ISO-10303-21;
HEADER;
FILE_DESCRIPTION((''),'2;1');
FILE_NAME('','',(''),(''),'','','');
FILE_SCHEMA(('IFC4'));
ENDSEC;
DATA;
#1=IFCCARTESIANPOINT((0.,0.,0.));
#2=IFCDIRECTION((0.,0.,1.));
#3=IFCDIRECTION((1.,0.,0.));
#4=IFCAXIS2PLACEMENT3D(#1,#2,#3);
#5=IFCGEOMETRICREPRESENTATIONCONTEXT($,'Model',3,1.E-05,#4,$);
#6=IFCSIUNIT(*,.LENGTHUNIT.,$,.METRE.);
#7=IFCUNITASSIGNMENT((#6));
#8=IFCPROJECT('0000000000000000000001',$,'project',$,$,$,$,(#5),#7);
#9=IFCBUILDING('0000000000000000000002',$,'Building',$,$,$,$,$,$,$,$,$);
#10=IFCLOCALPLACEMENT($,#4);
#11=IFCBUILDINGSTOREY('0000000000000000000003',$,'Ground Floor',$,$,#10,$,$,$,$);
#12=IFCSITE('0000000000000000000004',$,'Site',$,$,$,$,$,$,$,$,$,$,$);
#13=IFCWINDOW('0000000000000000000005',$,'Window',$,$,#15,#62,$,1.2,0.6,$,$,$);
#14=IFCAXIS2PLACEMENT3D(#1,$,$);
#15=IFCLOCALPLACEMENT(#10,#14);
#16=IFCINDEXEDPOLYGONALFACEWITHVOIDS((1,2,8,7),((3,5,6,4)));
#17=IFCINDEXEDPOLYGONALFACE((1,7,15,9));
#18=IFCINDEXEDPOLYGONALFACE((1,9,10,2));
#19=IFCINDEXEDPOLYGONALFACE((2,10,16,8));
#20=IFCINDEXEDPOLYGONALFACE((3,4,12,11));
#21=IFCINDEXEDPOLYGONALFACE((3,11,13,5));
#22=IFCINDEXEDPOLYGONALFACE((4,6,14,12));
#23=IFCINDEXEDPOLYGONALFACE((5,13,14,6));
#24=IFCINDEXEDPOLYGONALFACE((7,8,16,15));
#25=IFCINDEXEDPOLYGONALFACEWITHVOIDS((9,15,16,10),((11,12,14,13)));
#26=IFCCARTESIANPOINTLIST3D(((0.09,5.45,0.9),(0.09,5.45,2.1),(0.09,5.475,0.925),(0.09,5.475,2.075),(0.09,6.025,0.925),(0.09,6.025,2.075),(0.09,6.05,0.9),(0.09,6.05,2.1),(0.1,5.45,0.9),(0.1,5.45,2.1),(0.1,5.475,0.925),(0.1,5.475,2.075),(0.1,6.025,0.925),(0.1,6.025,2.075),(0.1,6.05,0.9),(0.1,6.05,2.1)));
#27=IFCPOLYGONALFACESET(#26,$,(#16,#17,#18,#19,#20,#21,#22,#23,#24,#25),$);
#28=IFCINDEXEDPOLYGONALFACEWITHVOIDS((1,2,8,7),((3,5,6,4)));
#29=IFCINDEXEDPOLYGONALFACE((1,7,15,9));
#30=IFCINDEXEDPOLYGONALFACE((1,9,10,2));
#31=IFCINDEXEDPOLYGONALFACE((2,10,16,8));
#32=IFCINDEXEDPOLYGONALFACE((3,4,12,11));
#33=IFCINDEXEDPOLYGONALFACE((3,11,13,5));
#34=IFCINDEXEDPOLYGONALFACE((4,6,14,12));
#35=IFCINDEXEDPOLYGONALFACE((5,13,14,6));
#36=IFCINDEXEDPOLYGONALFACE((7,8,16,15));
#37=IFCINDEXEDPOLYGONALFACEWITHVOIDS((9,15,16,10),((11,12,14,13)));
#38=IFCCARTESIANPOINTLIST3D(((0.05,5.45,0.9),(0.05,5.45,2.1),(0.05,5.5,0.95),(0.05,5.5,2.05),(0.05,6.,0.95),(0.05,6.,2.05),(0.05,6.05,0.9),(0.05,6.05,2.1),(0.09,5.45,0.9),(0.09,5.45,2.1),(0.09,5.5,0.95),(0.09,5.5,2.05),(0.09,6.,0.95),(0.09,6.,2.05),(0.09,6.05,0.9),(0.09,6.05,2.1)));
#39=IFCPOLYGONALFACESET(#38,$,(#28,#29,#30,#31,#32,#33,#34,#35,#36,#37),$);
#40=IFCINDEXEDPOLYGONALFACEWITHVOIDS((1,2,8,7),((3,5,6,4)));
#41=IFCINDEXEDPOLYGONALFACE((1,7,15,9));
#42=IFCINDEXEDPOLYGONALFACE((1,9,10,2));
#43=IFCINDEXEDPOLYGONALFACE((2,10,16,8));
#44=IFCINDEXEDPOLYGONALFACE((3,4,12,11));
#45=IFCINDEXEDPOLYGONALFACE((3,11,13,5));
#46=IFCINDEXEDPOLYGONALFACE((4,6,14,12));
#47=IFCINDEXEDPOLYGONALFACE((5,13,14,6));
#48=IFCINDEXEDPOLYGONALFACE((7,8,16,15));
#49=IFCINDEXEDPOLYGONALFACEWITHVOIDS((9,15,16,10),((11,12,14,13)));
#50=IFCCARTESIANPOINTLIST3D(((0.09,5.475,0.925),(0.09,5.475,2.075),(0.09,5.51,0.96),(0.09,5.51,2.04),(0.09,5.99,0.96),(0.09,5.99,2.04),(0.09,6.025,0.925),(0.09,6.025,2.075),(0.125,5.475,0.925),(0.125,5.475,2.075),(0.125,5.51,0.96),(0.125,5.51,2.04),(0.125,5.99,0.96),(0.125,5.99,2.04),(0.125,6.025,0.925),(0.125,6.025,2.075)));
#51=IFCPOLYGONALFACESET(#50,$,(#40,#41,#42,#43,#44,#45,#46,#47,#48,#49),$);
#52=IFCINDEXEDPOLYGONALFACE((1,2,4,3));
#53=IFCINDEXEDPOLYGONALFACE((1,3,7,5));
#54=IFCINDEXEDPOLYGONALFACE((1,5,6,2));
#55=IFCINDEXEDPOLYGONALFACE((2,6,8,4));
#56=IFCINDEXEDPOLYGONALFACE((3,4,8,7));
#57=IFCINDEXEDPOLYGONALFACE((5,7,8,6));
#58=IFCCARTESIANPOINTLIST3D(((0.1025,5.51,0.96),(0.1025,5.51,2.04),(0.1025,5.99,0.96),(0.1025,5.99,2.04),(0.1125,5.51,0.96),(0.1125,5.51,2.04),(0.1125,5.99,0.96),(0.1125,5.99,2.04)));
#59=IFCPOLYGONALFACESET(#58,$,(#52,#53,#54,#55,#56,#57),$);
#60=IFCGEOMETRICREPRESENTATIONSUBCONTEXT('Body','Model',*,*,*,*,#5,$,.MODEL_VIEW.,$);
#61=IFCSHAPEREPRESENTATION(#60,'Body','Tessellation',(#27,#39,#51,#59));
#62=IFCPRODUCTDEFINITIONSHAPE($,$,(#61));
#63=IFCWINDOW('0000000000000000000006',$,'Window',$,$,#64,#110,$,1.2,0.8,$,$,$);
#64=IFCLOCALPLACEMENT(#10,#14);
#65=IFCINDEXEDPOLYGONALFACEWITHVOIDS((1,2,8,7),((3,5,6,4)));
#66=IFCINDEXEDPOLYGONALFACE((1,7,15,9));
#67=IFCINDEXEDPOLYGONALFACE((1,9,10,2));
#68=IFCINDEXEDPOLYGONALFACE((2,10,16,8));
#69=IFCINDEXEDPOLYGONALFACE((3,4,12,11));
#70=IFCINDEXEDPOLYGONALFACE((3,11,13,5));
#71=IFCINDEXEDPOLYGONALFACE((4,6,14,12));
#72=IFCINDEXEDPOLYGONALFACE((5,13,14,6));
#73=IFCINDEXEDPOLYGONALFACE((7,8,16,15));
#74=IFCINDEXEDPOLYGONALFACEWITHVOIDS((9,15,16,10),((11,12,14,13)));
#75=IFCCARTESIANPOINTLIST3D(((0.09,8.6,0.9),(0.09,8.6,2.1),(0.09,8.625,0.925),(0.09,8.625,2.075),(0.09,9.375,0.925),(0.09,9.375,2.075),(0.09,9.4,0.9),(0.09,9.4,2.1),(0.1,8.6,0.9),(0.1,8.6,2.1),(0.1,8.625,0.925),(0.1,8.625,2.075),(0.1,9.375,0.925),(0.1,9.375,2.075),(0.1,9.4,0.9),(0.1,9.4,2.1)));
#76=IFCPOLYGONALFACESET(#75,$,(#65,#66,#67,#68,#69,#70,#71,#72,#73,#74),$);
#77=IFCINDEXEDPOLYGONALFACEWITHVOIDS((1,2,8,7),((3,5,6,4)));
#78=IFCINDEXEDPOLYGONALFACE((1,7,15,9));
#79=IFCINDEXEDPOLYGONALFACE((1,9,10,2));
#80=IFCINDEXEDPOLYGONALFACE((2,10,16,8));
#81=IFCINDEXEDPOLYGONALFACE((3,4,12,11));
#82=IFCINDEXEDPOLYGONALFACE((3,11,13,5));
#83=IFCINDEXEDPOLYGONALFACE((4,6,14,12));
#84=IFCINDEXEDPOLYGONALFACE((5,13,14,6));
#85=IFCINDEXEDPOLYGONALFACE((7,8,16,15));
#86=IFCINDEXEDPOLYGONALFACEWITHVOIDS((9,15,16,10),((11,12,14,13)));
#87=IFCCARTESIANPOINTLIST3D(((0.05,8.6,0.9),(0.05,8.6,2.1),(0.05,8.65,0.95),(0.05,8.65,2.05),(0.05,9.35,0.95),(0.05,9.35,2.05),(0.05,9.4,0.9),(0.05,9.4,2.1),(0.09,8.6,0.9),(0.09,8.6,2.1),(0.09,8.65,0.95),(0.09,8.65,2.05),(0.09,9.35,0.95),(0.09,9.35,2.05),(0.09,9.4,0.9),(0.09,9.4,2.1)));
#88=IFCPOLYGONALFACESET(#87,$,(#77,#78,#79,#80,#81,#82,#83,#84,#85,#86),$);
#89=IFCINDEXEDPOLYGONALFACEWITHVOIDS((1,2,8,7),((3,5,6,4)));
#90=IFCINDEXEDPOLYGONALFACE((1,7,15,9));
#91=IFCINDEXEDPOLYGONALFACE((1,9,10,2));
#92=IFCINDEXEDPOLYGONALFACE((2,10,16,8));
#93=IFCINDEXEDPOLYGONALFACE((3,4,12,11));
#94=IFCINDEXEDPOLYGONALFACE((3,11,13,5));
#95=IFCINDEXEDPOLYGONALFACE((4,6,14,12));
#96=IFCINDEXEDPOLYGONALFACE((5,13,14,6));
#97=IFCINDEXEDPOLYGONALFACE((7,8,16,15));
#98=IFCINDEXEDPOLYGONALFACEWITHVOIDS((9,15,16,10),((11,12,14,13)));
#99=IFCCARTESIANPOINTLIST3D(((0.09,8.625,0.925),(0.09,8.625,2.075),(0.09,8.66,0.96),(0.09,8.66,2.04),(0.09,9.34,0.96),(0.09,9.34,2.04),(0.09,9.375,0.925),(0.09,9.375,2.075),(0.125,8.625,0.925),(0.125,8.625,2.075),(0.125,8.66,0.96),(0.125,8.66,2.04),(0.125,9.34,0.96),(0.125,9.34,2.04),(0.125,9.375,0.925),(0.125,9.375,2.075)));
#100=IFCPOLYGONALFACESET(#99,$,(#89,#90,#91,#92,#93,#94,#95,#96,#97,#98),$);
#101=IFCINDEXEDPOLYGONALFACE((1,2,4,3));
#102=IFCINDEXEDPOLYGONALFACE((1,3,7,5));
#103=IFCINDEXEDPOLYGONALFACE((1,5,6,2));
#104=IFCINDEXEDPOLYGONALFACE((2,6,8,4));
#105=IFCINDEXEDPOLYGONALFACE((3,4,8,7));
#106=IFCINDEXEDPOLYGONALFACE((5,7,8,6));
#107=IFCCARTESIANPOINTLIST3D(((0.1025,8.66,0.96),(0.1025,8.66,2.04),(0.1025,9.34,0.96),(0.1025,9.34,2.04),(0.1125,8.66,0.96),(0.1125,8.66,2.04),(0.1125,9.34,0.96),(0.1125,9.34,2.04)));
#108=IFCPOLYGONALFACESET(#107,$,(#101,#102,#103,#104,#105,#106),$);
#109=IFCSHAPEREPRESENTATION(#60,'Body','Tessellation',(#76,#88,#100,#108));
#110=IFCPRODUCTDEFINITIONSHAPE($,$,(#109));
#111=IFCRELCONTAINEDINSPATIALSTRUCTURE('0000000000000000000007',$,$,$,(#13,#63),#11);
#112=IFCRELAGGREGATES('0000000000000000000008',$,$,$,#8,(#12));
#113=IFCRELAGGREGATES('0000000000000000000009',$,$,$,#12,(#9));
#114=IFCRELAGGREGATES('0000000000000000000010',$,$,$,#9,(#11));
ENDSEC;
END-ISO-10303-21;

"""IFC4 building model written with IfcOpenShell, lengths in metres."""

from ifc_helpers import new_model, si_unit, frame, origin_with_axes, place, context, subcontext, project, spatial, line, indexed_curve, outline, extrude, element, save


model = new_model("IFC4")

# Units and contexts
model_context = context("Model", 3, precision=1e-05, world=origin_with_axes())
body_context = subcontext(model_context, "Body", "Model", "MODEL_VIEW")
ifc_project = project(units=[si_unit("LENGTHUNIT", "METRE")], contexts=[model_context])

# Site, building, storey
site = spatial("IfcSite", under=ifc_project, Name="Site")
building = spatial("IfcBuilding", under=site, Name="Building")
storey_placement = place(None, origin_with_axes())
storey = spatial("IfcBuildingStorey", under=building, at=storey_placement, Name="Ground Floor")

# Windows
window_1_placement = place(storey_placement, frame((0.0, 6.05, 0.9), z_axis=(0.0, 0.0, 1.0), x_axis=(0.0, -1.0, 0.0)))
element("IfcWindow", 1, at=window_1_placement, inside=storey, Name="Window", OverallHeight=1.2, OverallWidth=0.6, context=body_context, shape_type="SweptSolid", body=[
    extrude(outline(indexed_curve([(0.0, 0.0), (0.6, 0.0), (0.6, 1.2), (0.0, 1.2)], segments=[line(1, 2, 3, 4, 1)]), holes=[indexed_curve([(0.025, 0.025), (0.575, 0.025), (0.575, 1.175), (0.025, 1.175)], segments=[line(1, 2, 3, 4, 1)])]), frame((0.0, 0.09, 0.0), z_axis=(0.0, -1.0, 0.0), x_axis=(1.0, 0.0, 0.0)), (0.0, 0.0, -1.0), 0.01),
    extrude(outline(indexed_curve([(0.0, 0.0), (0.6, 0.0), (0.6, 1.2), (0.0, 1.2)], segments=[line(1, 2, 3, 4, 1)]), holes=[indexed_curve([(0.05, 0.05), (0.55, 0.05), (0.55, 1.15), (0.05, 1.15)], segments=[line(1, 2, 3, 4, 1)])]), frame((0.0, 0.05, 0.0), z_axis=(0.0, -1.0, 0.0), x_axis=(1.0, 0.0, 0.0)), (0.0, 0.0, -1.0), 0.04),
    extrude(outline(indexed_curve([(0.0, 0.0), (0.55, 0.0), (0.55, 1.15), (0.0, 1.15)], segments=[line(1, 2, 3, 4, 1)]), holes=[indexed_curve([(0.035, 0.035), (0.515, 0.035), (0.515, 1.115), (0.035, 1.115)], segments=[line(1, 2, 3, 4, 1)])]), frame((0.025, 0.09, 0.025), z_axis=(0.0, -1.0, 0.0), x_axis=(1.0, 0.0, 0.0)), (0.0, 0.0, -1.0), 0.035),
    extrude(outline(indexed_curve([(0.035, 0.035), (0.515, 0.035), (0.515, 1.115), (0.035, 1.115)], segments=[line(1, 2, 3, 4, 1)])), frame((0.025, 0.1025, 0.025), z_axis=(0.0, -1.0, 0.0), x_axis=(1.0, 0.0, 0.0)), (0.0, 0.0, -1.0), 0.01),
])
window_2_placement = place(storey_placement, frame((0.0, 9.4, 0.9), z_axis=(0.0, 0.0, 1.0), x_axis=(0.0, -1.0, 0.0)))
element("IfcWindow", 2, at=window_2_placement, inside=storey, Name="Window", OverallHeight=1.2, OverallWidth=0.8, context=body_context, shape_type="SweptSolid", body=[
    extrude(outline(indexed_curve([(0.0, 0.0), (0.8, 0.0), (0.8, 1.2), (0.0, 1.2)], segments=[line(1, 2, 3, 4, 1)]), holes=[indexed_curve([(0.025, 0.025), (0.775, 0.025), (0.775, 1.175), (0.025, 1.175)], segments=[line(1, 2, 3, 4, 1)])]), frame((0.0, 0.09, 0.0), z_axis=(0.0, -1.0, 0.0), x_axis=(1.0, 0.0, 0.0)), (0.0, 0.0, -1.0), 0.01),
    extrude(outline(indexed_curve([(0.0, 0.0), (0.8, 0.0), (0.8, 1.2), (0.0, 1.2)], segments=[line(1, 2, 3, 4, 1)]), holes=[indexed_curve([(0.05, 0.05), (0.75, 0.05), (0.75, 1.15), (0.05, 1.15)], segments=[line(1, 2, 3, 4, 1)])]), frame((0.0, 0.05, 0.0), z_axis=(0.0, -1.0, 0.0), x_axis=(1.0, 0.0, 0.0)), (0.0, 0.0, -1.0), 0.04),
    extrude(outline(indexed_curve([(0.0, 0.0), (0.75, 0.0), (0.75, 1.15), (0.0, 1.15)], segments=[line(1, 2, 3, 4, 1)]), holes=[indexed_curve([(0.035, 0.035), (0.715, 0.035), (0.715, 1.115), (0.035, 1.115)], segments=[line(1, 2, 3, 4, 1)])]), frame((0.025, 0.09, 0.025), z_axis=(0.0, -1.0, 0.0), x_axis=(1.0, 0.0, 0.0)), (0.0, 0.0, -1.0), 0.035),
    extrude(outline(indexed_curve([(0.035, 0.035), (0.715, 0.035), (0.715, 1.115), (0.035, 1.115)], segments=[line(1, 2, 3, 4, 1)])), frame((0.025, 0.1025, 0.025), z_axis=(0.0, -1.0, 0.0), x_axis=(1.0, 0.0, 0.0)), (0.0, 0.0, -1.0), 0.01),
])

save(model, "model.ifc")
